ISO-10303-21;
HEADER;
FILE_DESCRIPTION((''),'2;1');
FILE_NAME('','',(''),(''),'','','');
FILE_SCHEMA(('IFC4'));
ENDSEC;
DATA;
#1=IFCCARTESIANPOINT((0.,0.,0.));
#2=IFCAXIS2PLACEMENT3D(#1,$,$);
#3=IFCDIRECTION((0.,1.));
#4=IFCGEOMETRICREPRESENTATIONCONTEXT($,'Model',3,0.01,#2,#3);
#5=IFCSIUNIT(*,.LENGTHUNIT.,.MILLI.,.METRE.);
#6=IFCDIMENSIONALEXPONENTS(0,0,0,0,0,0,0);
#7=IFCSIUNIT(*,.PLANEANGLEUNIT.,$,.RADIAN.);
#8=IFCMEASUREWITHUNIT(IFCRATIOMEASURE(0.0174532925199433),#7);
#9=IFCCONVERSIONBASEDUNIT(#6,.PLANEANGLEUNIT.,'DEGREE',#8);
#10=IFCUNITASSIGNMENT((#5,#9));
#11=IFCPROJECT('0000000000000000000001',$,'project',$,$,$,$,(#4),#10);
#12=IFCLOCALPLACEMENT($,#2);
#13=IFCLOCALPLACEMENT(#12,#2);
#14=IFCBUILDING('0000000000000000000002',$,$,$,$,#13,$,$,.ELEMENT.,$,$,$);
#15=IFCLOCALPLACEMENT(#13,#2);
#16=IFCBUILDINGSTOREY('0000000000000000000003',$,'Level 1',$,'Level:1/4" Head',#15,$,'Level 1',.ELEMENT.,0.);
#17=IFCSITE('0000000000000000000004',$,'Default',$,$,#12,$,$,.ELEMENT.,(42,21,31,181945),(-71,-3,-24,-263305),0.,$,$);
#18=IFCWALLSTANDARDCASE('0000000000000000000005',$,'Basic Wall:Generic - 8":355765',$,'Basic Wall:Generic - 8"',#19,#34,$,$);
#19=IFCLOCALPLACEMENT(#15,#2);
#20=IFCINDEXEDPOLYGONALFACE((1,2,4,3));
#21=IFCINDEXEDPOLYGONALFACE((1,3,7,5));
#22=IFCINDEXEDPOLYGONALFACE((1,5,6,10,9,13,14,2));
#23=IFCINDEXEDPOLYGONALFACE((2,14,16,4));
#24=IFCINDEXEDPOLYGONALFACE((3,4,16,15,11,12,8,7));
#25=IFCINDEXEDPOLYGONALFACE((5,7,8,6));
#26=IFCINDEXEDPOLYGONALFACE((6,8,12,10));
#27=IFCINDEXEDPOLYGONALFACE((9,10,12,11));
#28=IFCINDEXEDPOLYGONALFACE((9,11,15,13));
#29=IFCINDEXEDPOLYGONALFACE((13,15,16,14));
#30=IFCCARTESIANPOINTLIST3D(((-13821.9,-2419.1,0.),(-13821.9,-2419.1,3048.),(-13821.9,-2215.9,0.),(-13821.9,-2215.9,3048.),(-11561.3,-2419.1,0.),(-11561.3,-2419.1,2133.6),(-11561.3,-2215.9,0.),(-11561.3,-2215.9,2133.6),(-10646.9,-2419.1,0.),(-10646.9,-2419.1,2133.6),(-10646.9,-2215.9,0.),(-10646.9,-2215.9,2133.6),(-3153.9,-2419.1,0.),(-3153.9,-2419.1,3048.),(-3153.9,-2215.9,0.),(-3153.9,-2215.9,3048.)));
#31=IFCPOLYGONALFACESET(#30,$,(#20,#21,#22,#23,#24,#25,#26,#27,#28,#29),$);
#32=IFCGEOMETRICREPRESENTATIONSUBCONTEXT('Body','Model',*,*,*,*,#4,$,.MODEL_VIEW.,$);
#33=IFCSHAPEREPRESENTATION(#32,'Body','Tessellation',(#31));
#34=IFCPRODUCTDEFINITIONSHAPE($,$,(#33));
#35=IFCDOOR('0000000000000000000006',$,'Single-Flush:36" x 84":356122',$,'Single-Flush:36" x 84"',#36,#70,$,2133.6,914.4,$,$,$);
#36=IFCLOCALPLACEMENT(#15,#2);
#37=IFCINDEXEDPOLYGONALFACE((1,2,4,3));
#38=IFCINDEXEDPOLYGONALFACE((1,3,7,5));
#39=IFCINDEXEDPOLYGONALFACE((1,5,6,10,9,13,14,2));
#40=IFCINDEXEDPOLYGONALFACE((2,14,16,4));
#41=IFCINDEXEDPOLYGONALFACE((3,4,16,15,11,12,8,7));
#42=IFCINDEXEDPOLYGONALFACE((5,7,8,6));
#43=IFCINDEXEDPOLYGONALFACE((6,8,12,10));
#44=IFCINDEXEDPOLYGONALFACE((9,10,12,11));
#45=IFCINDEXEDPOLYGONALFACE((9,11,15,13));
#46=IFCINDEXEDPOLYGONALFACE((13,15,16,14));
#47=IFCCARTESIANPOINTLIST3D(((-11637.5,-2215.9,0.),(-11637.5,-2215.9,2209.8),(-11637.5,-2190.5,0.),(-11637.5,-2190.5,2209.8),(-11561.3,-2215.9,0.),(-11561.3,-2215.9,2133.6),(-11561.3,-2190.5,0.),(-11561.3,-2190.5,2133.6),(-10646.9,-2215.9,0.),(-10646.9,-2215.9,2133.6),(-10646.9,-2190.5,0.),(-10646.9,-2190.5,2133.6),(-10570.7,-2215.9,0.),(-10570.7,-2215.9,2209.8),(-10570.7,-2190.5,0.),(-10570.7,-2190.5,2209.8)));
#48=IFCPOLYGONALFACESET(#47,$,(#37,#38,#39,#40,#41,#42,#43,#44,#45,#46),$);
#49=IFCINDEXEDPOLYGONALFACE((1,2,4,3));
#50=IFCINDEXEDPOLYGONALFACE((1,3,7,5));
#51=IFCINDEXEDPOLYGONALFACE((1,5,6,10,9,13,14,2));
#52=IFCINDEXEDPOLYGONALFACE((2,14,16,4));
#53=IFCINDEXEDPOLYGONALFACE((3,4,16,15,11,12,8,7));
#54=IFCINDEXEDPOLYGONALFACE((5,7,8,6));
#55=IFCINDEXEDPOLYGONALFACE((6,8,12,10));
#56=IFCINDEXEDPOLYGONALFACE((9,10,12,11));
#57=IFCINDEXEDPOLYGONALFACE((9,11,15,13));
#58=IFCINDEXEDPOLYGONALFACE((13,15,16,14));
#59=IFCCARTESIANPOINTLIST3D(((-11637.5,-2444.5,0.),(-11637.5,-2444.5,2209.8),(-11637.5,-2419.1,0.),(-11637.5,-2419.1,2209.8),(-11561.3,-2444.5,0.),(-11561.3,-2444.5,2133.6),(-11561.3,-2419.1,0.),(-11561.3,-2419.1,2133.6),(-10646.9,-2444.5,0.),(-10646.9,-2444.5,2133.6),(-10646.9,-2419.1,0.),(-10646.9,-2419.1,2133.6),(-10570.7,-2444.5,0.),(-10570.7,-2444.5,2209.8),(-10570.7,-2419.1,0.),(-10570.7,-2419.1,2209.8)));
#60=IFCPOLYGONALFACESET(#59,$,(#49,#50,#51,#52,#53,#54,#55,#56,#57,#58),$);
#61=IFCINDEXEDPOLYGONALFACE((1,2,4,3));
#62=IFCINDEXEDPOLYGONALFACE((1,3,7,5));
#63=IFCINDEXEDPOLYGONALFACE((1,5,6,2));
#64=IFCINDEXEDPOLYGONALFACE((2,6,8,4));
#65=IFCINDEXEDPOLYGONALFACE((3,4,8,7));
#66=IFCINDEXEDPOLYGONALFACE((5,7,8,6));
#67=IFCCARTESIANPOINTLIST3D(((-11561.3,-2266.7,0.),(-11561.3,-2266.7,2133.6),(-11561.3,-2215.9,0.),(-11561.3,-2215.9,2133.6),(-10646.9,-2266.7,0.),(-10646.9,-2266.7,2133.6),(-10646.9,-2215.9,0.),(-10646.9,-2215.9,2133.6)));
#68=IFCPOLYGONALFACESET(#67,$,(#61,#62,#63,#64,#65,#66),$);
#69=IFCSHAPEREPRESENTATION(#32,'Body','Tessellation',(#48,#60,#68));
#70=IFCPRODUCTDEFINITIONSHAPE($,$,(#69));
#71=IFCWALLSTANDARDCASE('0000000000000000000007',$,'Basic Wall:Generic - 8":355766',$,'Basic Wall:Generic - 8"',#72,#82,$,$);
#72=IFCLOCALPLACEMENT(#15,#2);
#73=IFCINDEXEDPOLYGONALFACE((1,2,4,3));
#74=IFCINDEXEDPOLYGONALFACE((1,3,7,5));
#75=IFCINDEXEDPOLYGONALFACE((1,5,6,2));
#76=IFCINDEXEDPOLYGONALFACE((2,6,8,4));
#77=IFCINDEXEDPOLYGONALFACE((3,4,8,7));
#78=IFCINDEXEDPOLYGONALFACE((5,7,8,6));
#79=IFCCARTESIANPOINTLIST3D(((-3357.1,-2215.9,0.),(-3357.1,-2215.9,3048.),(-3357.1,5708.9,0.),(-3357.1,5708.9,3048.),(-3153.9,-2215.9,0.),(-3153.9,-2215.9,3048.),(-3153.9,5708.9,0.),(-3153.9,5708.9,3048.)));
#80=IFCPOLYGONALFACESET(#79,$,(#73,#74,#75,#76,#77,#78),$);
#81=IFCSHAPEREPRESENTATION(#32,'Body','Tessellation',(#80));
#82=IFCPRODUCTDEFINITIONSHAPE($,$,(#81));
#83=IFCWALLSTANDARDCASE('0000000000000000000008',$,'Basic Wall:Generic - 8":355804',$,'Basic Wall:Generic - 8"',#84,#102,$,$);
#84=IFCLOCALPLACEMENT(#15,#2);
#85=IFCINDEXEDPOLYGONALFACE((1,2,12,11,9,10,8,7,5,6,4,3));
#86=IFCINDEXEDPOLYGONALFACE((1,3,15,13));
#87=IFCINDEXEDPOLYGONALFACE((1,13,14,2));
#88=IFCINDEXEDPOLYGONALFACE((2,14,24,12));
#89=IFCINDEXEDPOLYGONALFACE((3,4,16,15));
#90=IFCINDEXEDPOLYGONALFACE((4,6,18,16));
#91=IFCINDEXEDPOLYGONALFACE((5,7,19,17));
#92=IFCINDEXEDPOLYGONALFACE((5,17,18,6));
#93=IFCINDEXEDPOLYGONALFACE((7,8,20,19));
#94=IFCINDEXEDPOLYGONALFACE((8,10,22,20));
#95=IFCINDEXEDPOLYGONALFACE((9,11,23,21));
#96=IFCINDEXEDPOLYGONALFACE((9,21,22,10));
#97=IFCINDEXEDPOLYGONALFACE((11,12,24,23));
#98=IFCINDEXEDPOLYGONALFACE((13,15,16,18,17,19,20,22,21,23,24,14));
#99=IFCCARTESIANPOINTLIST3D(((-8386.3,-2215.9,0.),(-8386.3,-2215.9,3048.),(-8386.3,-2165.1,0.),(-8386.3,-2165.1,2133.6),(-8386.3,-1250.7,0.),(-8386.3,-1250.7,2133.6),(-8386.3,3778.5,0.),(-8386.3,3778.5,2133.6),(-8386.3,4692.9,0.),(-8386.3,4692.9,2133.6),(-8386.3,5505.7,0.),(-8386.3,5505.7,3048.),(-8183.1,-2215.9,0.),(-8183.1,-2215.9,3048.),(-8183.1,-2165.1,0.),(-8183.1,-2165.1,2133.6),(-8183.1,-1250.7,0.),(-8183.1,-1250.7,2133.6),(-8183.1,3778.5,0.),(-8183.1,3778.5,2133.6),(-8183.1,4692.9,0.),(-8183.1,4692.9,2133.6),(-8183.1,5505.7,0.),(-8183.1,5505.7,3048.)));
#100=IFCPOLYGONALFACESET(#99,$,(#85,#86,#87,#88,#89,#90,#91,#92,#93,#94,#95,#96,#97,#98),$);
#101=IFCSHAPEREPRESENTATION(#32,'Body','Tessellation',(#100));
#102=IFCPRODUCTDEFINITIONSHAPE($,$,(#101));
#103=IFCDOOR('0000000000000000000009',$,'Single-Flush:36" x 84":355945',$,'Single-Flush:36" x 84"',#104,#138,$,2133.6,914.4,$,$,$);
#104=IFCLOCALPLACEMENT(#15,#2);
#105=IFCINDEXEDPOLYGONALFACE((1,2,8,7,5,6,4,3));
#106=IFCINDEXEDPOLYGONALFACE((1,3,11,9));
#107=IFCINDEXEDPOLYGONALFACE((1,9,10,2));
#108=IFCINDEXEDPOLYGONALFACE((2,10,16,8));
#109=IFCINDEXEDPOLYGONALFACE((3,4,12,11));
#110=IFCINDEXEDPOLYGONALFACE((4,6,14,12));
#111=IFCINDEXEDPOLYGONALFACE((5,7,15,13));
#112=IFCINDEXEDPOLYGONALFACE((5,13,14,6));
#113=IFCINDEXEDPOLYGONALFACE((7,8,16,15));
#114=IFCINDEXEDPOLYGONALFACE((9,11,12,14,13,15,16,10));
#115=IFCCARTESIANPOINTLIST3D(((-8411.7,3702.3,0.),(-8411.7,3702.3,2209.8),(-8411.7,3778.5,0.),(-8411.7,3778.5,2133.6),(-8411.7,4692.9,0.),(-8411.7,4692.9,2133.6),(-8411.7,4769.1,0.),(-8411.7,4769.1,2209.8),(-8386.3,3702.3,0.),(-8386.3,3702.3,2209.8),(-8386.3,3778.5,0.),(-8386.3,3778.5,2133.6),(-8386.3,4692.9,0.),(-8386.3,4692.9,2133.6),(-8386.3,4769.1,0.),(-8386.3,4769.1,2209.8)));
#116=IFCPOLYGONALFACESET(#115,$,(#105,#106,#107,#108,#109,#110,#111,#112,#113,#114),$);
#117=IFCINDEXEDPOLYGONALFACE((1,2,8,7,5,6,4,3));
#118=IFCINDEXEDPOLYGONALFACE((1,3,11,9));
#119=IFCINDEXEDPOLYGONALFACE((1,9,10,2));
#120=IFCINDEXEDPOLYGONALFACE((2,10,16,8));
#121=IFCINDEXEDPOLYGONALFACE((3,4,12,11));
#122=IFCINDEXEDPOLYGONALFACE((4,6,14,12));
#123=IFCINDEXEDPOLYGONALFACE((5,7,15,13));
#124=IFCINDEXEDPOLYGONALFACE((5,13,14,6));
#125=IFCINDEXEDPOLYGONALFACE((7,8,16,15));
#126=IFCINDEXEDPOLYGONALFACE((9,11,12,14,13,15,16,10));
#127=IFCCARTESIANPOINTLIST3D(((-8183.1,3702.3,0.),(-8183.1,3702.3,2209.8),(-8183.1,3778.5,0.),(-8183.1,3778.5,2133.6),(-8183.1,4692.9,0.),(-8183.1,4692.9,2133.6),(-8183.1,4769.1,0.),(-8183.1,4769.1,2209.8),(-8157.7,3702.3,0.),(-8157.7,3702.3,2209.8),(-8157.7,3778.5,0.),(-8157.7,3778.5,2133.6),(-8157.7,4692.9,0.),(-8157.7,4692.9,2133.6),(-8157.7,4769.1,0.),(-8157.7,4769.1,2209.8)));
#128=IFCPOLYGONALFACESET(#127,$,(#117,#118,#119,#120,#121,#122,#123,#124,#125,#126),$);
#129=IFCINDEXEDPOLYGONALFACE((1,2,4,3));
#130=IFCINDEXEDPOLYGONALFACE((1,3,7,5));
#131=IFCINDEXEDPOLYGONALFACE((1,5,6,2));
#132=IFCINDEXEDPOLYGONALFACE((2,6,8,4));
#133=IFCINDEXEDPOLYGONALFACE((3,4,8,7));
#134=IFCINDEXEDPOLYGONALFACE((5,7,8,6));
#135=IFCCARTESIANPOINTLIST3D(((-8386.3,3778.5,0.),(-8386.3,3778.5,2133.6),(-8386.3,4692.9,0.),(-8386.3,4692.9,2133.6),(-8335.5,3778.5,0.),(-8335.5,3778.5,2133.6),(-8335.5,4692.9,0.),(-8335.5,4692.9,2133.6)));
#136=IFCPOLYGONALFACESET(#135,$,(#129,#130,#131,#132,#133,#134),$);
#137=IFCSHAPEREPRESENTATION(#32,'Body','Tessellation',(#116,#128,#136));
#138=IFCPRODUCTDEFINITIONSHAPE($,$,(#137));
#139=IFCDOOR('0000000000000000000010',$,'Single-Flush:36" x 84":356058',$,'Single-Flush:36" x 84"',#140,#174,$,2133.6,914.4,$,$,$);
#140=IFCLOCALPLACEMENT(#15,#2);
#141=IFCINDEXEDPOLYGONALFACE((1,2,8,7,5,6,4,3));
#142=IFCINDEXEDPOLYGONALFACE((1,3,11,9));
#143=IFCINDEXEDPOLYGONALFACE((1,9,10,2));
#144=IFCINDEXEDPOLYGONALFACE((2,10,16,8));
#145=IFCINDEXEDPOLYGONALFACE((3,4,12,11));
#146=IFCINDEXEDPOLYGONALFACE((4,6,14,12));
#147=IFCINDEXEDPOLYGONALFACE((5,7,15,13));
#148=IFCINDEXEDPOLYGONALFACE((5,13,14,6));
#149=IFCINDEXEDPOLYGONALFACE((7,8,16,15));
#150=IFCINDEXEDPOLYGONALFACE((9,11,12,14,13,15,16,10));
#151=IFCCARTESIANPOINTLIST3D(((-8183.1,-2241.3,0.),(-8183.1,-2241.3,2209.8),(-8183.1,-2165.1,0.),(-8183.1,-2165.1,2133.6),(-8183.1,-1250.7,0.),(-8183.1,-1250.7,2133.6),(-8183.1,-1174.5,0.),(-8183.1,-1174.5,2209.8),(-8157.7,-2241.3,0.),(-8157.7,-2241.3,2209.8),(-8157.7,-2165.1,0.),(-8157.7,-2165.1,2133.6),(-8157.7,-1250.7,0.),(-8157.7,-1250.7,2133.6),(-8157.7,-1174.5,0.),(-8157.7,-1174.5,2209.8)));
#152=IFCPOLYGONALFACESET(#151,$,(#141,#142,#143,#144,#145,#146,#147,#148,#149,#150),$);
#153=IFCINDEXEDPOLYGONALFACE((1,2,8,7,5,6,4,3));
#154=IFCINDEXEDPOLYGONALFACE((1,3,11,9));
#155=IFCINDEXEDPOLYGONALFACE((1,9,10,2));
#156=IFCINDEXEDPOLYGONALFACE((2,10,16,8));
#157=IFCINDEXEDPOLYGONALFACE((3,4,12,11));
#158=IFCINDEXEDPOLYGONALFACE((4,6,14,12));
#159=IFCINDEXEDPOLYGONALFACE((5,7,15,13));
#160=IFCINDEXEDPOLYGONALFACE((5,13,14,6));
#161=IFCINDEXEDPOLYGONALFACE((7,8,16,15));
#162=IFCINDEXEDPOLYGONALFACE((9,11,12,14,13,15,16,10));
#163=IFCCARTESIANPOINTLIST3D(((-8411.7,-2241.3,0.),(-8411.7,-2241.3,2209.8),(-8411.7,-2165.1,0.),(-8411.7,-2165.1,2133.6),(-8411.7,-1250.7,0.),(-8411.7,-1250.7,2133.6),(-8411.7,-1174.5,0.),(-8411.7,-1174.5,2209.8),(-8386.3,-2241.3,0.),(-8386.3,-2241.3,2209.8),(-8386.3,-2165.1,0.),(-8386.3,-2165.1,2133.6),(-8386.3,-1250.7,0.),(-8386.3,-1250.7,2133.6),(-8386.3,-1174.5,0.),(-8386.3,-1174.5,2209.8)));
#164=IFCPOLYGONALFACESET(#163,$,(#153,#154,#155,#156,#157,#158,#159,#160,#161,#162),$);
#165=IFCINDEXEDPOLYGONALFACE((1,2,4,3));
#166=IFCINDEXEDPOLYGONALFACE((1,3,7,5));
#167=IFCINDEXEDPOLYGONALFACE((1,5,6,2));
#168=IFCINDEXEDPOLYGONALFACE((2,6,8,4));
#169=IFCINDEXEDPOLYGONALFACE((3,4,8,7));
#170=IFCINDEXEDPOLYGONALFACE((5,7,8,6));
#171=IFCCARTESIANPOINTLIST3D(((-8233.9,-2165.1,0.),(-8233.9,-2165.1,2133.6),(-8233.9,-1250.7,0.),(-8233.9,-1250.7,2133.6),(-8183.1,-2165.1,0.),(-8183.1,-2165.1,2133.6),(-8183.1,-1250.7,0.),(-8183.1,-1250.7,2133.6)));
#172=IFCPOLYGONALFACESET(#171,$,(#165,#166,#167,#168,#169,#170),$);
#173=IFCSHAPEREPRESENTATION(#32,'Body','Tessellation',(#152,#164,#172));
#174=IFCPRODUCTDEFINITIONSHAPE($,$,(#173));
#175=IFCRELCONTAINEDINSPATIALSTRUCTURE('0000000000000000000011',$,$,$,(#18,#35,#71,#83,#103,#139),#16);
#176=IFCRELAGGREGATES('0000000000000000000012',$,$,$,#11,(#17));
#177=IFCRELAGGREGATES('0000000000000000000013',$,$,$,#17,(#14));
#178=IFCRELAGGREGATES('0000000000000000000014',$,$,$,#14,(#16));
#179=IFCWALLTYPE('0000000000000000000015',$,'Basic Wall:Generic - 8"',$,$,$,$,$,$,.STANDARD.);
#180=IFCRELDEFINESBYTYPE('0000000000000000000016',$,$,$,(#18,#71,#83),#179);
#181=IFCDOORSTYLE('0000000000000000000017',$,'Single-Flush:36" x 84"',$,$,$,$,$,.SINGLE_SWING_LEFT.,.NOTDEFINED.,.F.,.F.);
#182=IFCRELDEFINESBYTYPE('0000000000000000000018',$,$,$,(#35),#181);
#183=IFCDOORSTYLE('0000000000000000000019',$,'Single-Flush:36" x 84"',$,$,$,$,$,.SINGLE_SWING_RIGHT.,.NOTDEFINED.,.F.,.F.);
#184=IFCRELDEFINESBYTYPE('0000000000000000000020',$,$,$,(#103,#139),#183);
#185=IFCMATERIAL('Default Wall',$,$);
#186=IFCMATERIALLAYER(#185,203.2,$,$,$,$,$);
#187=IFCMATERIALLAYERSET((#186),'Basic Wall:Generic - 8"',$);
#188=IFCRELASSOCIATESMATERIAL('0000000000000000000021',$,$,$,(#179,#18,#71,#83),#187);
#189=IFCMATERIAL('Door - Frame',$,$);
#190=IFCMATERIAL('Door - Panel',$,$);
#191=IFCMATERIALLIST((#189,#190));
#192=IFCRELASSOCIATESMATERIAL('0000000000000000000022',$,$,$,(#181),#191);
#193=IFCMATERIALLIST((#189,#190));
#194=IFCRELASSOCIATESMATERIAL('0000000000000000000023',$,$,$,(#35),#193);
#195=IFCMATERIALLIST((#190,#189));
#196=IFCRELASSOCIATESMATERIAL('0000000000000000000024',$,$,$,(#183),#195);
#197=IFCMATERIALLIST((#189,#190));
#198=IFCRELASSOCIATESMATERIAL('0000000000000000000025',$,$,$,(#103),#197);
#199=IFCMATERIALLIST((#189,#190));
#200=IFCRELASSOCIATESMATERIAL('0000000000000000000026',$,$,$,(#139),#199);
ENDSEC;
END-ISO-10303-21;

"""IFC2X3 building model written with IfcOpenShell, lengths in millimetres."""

from ifc_helpers import new_model, entity, si_unit, converted_unit, direction, frame, frame_2d, origin, place, context, subcontext, project, spatial, polyline, rectangle, outline, extrude, source, transform, mapped, material, material_list, layer, layer_set, layer_usage, type_object, type_shapes, element, fill, save


model = new_model("IFC2X3")

# Units and contexts
model_context = context("Model", 3, precision=0.01, world=origin(), true_north=direction((0.0, 1.0)))
body_context = subcontext(model_context, "Body", "Model", "MODEL_VIEW")
ifc_project = project(units=[si_unit("LENGTHUNIT", "METRE", prefix="MILLI"), converted_unit("PLANEANGLEUNIT", "DEGREE", entity("IfcRatioMeasure", 0.0174532925199433), si_unit("PLANEANGLEUNIT", "RADIAN"), dimensions=[0, 0, 0, 0, 0, 0, 0])], contexts=[model_context])

# Site, building, storey
site_placement = place(None, origin())
site = spatial("IfcSite", under=ifc_project, at=site_placement, Name="Default", CompositionType="ELEMENT", RefLatitude=(42, 21, 31, 181945), RefLongitude=(-71, -3, -24, -263305), RefElevation=0.0)
building_placement = place(site_placement, origin())
building = spatial("IfcBuilding", under=site, at=building_placement, CompositionType="ELEMENT")
storey_placement = place(building_placement, origin())
storey = spatial("IfcBuildingStorey", under=building, at=storey_placement, Name="Level 1", ObjectType="Level:1/4\" Head", LongName="Level 1", CompositionType="ELEMENT", Elevation=0.0)

# Shared definitions
ifc_material_1 = material(Name="Default Wall")
ifc_layer_1 = layer(ifc_material_1, 203.2)
ifc_layer_set_1 = layer_set([ifc_layer_1], Name="Basic Wall:Generic - 8\"")
wall_type_1 = type_object("IfcWallType", Name="Basic Wall:Generic - 8\"", PredefinedType="STANDARD", material=ifc_layer_set_1)

# Wall, opening, door
ifc_layer_usage_1 = layer_usage(ifc_layer_set_1, "AXIS2", "NEGATIVE", 101.6)
wall_1_placement = place(storey_placement, frame((-3153.9, -2317.5, 0.0), z_axis=(0.0, 0.0, 1.0), x_axis=(-1.0, 0.0, 0.0)))
wall_1 = element("IfcWallStandardCase", 1, at=wall_1_placement, inside=storey, type_object=wall_type_1, material=ifc_layer_usage_1, Name="Basic Wall:Generic - 8\":355765", ObjectType="Basic Wall:Generic - 8\"", context=body_context, shape_type="SweptSolid", body=[
    extrude(rectangle(XDim=10668.0, YDim=203.2, at=frame_2d((5334.0, 0.0), x_axis=(-1.0, 0.0))), origin(), (0.0, 0.0, 1.0), 3048.0),
])
opening_1_placement = place(wall_1_placement, frame((8407.4, 101.6, 0.0)))
opening_1 = element("IfcOpeningElement", 2, at=opening_1_placement, cuts=wall_1, ObjectType="Opening", context=body_context, shape_type="SweptSolid", body=[
    extrude(rectangle(XDim=914.4, YDim=2133.6, at=frame_2d((1066.8, 457.2), x_axis=(0.0, -1.0))), frame((0.0, 0.0, 0.0), z_axis=(0.0, -1.0, 0.0), x_axis=(0.0, 0.0, 1.0)), (0.0, 0.0, 1.0), 203.2),
])
ifc_material_2 = material(Name="Door - Frame")
ifc_material_3 = material(Name="Door - Panel")
ifc_material_list_1 = material_list([ifc_material_2, ifc_material_3])
ifc_material_list_2 = material_list([ifc_material_2, ifc_material_3])
door_style_1 = type_object("IfcDoorStyle", Name="Single-Flush:36\" x 84\"", ConstructionType="NOTDEFINED", OperationType="SINGLE_SWING_LEFT", ParameterTakesPrecedence=False, Sizeable=False, material=ifc_material_list_2)
shared_shape_1 = source(origin(), body_context, "Body", "SweptSolid", [
    extrude(outline(polyline([(-533.4, -1124.0), (533.4, -1124.0), (533.4, 1085.8), (457.2, 1085.8), (457.2, -1047.8), (-457.2, -1047.8), (-457.2, 1085.8), (-533.4, 1085.8), (-533.4, -1124.0)])), frame((457.2, 228.6, 1085.8), z_axis=(0.0, -1.0, 0.0), x_axis=(-1.0, 0.0, 0.0)), (0.0, 0.0, 1.0), 25.4),
    extrude(outline(polyline([(-1124.0, -533.4), (1085.8, -533.4), (1085.8, -457.2), (-1047.8, -457.2), (-1047.8, 457.2), (1085.8, 457.2), (1085.8, 533.4), (-1124.0, 533.4), (-1124.0, -533.4)])), frame((457.2, 0.0, 1085.8), z_axis=(0.0, -1.0, 0.0), x_axis=(0.0, 0.0, -1.0)), (0.0, 0.0, 1.0), 25.4),
    extrude(rectangle(XDim=914.4, YDim=50.8, at=frame_2d((0.0, 0.0), x_axis=(1.0, 0.0))), frame((457.2, 177.8, 0.0)), (0.0, 0.0, 1.0), 2133.6),
])
type_shapes(door_style_1, [shared_shape_1])
door_1_placement = place(opening_1_placement, frame((0.0, 0.0, 0.0), z_axis=(0.0, 0.0, 1.0), x_axis=(-1.0, 0.0, 0.0)))
door_1 = element("IfcDoor", 3, at=door_1_placement, inside=storey, type_object=door_style_1, material=ifc_material_list_1, Name="Single-Flush:36\" x 84\":356122", ObjectType="Single-Flush:36\" x 84\"", OverallHeight=2133.6, OverallWidth=914.4, context=body_context, shape_type="MappedRepresentation", body=[
    mapped(shared_shape_1, transform((0.0, 0.0, 0.0), scale=1.0)),
])
fill(opening_1, door_1)

# Wall
ifc_layer_usage_2 = layer_usage(ifc_layer_set_1, "AXIS2", "NEGATIVE", 101.6)
wall_2_placement = place(storey_placement, frame((-3255.5, 5708.9, 0.0), z_axis=(0.0, 0.0, 1.0), x_axis=(0.0, -1.0, 0.0)))
element("IfcWallStandardCase", 4, at=wall_2_placement, inside=storey, type_object=wall_type_1, material=ifc_layer_usage_2, Name="Basic Wall:Generic - 8\":355766", ObjectType="Basic Wall:Generic - 8\"", context=body_context, shape_type="SweptSolid", body=[
    extrude(rectangle(XDim=7924.8, YDim=203.2, at=frame_2d((3962.4, 0.0), x_axis=(-1.0, 0.0))), origin(), (0.0, 0.0, 1.0), 3048.0),
])

# Wall, openings, doors
ifc_layer_usage_3 = layer_usage(ifc_layer_set_1, "AXIS2", "NEGATIVE", 101.6)
wall_3_placement = place(storey_placement, frame((-8284.7, 5505.7, 0.0), z_axis=(0.0, 0.0, 1.0), x_axis=(0.0, -1.0, 0.0)))
wall_3 = element("IfcWallStandardCase", 5, at=wall_3_placement, inside=storey, type_object=wall_type_1, material=ifc_layer_usage_3, Name="Basic Wall:Generic - 8\":355804", ObjectType="Basic Wall:Generic - 8\"", context=body_context, shape_type="SweptSolid", body=[
    extrude(rectangle(XDim=7721.6, YDim=203.2, at=frame_2d((3860.8, 0.0), x_axis=(-1.0, 0.0))), origin(), (0.0, 0.0, 1.0), 3048.0),
])
opening_2_placement = place(wall_3_placement, frame((1727.2, 101.6, 0.0)))
opening_2 = element("IfcOpeningElement", 6, at=opening_2_placement, cuts=wall_3, ObjectType="Opening", context=body_context, shape_type="SweptSolid", body=[
    extrude(rectangle(XDim=914.4, YDim=2133.6, at=frame_2d((1066.8, 457.2), x_axis=(0.0, 1.0))), frame((0.0, 0.0, 0.0), z_axis=(0.0, -1.0, 0.0), x_axis=(0.0, 0.0, 1.0)), (0.0, 0.0, 1.0), 203.2),
])
opening_3_placement = place(wall_3_placement, frame((6756.4, -101.6, 0.0)))
opening_3 = element("IfcOpeningElement", 7, at=opening_3_placement, cuts=wall_3, ObjectType="Opening", context=body_context, shape_type="SweptSolid", body=[
    extrude(rectangle(XDim=914.4, YDim=2133.6, at=frame_2d((1066.8, 457.2), x_axis=(0.0, 1.0))), frame((0.0, 0.0, 0.0), z_axis=(0.0, 1.0, 0.0), x_axis=(0.0, 0.0, 1.0)), (0.0, 0.0, 1.0), 203.2),
])
ifc_material_list_3 = material_list([ifc_material_2, ifc_material_3])
ifc_material_list_4 = material_list([ifc_material_3, ifc_material_2])
door_style_2 = type_object("IfcDoorStyle", Name="Single-Flush:36\" x 84\"", ConstructionType="NOTDEFINED", OperationType="SINGLE_SWING_RIGHT", ParameterTakesPrecedence=False, Sizeable=False, material=ifc_material_list_4)
shared_shape_2 = source(origin(), body_context, "Body", "SweptSolid", [
    extrude(outline(polyline([(-533.4, -1124.0), (533.4, -1124.0), (533.4, 1085.8), (457.2, 1085.8), (457.2, -1047.8), (-457.2, -1047.8), (-457.2, 1085.8), (-533.4, 1085.8), (-533.4, -1124.0)])), frame((457.2, 203.2, 1085.8), z_axis=(0.0, 1.0, 0.0), x_axis=(1.0, 0.0, 0.0)), (0.0, 0.0, 1.0), 25.4),
    extrude(outline(polyline([(-1124.0, -533.4), (1085.8, -533.4), (1085.8, -457.2), (-1047.8, -457.2), (-1047.8, 457.2), (1085.8, 457.2), (1085.8, 533.4), (-1124.0, 533.4), (-1124.0, -533.4)])), frame((457.2, -25.4, 1085.8), z_axis=(0.0, 1.0, 0.0), x_axis=(0.0, 0.0, -1.0)), (0.0, 0.0, 1.0), 25.4),
    extrude(rectangle(XDim=50.8, YDim=914.4, at=frame_2d((0.0, 0.0), x_axis=(1.0, 0.0))), frame((457.2, 177.8, 0.0), z_axis=(0.0, 0.0, 1.0), x_axis=(0.0, 1.0, 0.0)), (0.0, 0.0, 1.0), 2133.6),
])
type_shapes(door_style_2, [shared_shape_2])
door_2_placement = place(opening_2_placement, frame((0.0, 0.0, 0.0), z_axis=(0.0, 0.0, 1.0), x_axis=(-1.0, 0.0, 0.0)))
door_2 = element("IfcDoor", 8, at=door_2_placement, inside=storey, type_object=door_style_2, material=ifc_material_list_3, Name="Single-Flush:36\" x 84\":355945", ObjectType="Single-Flush:36\" x 84\"", OverallHeight=2133.6, OverallWidth=914.4, context=body_context, shape_type="MappedRepresentation", body=[
    mapped(shared_shape_2, transform((0.0, 0.0, 0.0), scale=1.0)),
])
fill(opening_2, door_2)
ifc_material_list_5 = material_list([ifc_material_2, ifc_material_3])
door_3_placement = place(opening_3_placement, origin())
door_3 = element("IfcDoor", 9, at=door_3_placement, inside=storey, type_object=door_style_2, material=ifc_material_list_5, Name="Single-Flush:36\" x 84\":356058", ObjectType="Single-Flush:36\" x 84\"", OverallHeight=2133.6, OverallWidth=914.4, context=body_context, shape_type="MappedRepresentation", body=[
    mapped(shared_shape_2, transform((0.0, 0.0, 0.0), scale=1.0)),
])
fill(opening_3, door_3)

save(model, "model.ifc")
